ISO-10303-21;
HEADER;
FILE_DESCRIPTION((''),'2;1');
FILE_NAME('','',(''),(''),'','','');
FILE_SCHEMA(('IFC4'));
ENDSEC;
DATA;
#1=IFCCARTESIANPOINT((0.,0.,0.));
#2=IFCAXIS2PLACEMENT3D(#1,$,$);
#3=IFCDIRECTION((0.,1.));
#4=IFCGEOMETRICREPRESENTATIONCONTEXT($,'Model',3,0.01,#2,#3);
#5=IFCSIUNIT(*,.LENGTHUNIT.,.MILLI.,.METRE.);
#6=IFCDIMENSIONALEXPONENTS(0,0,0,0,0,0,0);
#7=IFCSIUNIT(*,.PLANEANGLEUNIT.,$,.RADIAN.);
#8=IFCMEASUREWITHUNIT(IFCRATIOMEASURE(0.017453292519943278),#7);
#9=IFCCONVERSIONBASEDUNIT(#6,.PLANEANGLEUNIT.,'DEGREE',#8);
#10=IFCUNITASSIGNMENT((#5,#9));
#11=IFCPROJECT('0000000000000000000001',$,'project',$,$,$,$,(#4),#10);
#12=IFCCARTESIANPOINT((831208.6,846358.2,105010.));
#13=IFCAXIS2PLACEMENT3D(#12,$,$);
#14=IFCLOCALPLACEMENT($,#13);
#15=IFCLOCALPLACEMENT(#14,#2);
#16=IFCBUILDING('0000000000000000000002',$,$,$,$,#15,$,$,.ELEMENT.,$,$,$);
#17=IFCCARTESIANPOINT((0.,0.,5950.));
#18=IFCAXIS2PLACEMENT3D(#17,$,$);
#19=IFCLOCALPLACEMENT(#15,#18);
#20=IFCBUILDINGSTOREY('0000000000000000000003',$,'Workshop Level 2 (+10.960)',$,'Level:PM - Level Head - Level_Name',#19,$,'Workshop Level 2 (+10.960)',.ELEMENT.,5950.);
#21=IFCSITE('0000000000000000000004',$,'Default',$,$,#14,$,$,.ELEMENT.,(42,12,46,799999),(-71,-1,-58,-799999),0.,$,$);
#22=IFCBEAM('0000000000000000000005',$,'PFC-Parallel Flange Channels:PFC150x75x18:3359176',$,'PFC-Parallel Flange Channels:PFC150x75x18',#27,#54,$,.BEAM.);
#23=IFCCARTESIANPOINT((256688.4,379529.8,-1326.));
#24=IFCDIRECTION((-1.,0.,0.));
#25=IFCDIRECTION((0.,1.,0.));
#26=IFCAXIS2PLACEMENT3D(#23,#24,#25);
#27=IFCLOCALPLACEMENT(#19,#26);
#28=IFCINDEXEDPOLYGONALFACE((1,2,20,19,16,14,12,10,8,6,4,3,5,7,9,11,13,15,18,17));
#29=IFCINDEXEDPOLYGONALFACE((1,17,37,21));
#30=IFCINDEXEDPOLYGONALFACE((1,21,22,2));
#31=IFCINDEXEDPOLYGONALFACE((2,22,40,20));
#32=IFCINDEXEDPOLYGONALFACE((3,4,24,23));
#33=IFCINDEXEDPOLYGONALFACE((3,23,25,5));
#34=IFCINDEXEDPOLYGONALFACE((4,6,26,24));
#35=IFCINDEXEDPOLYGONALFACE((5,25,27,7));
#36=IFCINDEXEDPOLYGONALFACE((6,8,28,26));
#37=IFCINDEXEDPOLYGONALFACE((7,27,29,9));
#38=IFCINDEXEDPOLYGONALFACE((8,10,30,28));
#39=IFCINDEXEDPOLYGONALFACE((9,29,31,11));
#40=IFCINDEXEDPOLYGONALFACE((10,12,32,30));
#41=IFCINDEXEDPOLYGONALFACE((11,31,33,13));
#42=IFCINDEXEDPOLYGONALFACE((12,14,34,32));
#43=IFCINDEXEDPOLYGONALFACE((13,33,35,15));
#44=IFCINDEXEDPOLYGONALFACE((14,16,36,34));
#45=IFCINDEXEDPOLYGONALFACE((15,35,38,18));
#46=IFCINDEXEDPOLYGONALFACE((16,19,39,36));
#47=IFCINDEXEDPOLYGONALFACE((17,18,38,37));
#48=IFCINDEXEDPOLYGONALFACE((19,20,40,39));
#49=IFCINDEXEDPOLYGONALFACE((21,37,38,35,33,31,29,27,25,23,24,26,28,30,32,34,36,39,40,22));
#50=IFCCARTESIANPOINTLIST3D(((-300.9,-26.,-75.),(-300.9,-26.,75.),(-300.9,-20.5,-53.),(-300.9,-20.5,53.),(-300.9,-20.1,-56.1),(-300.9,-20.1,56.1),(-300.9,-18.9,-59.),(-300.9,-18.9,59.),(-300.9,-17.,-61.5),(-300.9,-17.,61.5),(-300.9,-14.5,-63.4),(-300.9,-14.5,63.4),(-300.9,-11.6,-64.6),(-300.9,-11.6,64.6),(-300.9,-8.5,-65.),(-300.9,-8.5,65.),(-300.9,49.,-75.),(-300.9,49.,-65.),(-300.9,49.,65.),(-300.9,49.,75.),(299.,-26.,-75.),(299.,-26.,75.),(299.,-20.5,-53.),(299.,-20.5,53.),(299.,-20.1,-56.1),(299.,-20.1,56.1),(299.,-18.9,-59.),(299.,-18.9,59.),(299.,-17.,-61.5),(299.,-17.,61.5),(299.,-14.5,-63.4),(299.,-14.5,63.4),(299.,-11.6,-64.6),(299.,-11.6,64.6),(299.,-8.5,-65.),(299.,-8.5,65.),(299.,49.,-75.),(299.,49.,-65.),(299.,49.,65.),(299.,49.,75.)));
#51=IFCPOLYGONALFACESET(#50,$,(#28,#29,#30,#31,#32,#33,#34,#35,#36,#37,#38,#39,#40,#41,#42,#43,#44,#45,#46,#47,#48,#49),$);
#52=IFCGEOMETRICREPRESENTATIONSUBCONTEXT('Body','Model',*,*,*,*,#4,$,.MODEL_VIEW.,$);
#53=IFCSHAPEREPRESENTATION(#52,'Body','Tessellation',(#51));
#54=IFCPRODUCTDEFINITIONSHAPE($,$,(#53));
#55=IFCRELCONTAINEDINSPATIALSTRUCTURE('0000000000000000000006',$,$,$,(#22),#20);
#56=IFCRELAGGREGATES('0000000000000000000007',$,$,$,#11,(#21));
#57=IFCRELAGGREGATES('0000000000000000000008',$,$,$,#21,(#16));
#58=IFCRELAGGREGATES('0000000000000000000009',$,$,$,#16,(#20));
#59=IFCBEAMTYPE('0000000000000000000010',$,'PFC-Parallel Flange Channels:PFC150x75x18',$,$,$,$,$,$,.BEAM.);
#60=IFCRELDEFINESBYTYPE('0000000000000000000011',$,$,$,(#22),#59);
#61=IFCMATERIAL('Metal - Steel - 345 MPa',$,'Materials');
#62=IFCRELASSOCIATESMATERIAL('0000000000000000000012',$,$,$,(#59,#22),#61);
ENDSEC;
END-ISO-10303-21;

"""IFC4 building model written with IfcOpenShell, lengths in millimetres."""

from ifc_helpers import new_model, entity, si_unit, converted_unit, direction, frame, origin, place, context, subcontext, project, spatial, line, arc, indexed_curve, outline, extrude, source, transform, mapped, material, type_object, type_shapes, element, save


model = new_model("IFC4")

# Units and contexts
model_context = context("Model", 3, precision=0.01, world=origin(), true_north=direction((0.0, 1.0)))
body_context = subcontext(model_context, "Body", "Model", "MODEL_VIEW")
ifc_project = project(units=[si_unit("LENGTHUNIT", "METRE", prefix="MILLI"), converted_unit("PLANEANGLEUNIT", "DEGREE", entity("IfcRatioMeasure", 0.017453292519943278), si_unit("PLANEANGLEUNIT", "RADIAN"), dimensions=[0, 0, 0, 0, 0, 0, 0])], contexts=[model_context])

# Site, building, storey
site_placement = place(None, frame((831208.6, 846358.2, 105010.0)))
site = spatial("IfcSite", under=ifc_project, at=site_placement, Name="Default", CompositionType="ELEMENT", RefLatitude=(42, 12, 46, 799999), RefLongitude=(-71, -1, -58, -799999), RefElevation=0.0)
building_placement = place(site_placement, origin())
building = spatial("IfcBuilding", under=site, at=building_placement, CompositionType="ELEMENT")
storey_placement = place(building_placement, frame((0.0, 0.0, 5950.0)))
storey = spatial("IfcBuildingStorey", under=building, at=storey_placement, Name="Workshop Level 2 (+10.960)", ObjectType="Level:PM - Level Head - Level_Name", LongName="Workshop Level 2 (+10.960)", CompositionType="ELEMENT", Elevation=5950.0)

# Beam
ifc_material_1 = material(Name="Metal - Steel - 345 MPa", Category="Materials")
beam_type_1 = type_object("IfcBeamType", Name="PFC-Parallel Flange Channels:PFC150x75x18", PredefinedType="BEAM", material=ifc_material_1)
shared_shape_1 = source(origin(), body_context, "Body", "SweptSolid", [
    extrude(outline(indexed_curve([(-75.0, -34.6), (75.0, -34.6), (75.0, 40.4), (65.0, 40.4), (65.0, -17.1), (61.5, -25.6), (53.0, -29.1), (-53.0, -29.1), (-61.5, -25.6), (-65.0, -17.1), (-65.0, 40.4), (-75.0, 40.4)], segments=[line(1, 2, 3, 4, 5), arc(5, 6, 7), line(7, 8), arc(8, 9, 10), line(10, 11, 12, 1)], self_intersect=False)), frame((-300.9, 8.6, 0.0), z_axis=(1.0, 0.0, 0.0), x_axis=(0.0, 0.0, -1.0)), (0.0, 0.0, 1.0), 599.9),
])
type_shapes(beam_type_1, [shared_shape_1])
beam_1_placement = place(storey_placement, frame((256688.4, 379529.8, -1326.0), z_axis=(-1.0, 0.0, 0.0), x_axis=(0.0, 1.0, 0.0)))
element("IfcBeam", 1, at=beam_1_placement, inside=storey, type_object=beam_type_1, material=ifc_material_1, Name="PFC-Parallel Flange Channels:PFC150x75x18:3359176", ObjectType="PFC-Parallel Flange Channels:PFC150x75x18", PredefinedType="BEAM", context=body_context, shape_type="MappedRepresentation", body=[
    mapped(shared_shape_1, transform((0.0, 0.0, 0.0), scale=1.0)),
])

save(model, "model.ifc")
